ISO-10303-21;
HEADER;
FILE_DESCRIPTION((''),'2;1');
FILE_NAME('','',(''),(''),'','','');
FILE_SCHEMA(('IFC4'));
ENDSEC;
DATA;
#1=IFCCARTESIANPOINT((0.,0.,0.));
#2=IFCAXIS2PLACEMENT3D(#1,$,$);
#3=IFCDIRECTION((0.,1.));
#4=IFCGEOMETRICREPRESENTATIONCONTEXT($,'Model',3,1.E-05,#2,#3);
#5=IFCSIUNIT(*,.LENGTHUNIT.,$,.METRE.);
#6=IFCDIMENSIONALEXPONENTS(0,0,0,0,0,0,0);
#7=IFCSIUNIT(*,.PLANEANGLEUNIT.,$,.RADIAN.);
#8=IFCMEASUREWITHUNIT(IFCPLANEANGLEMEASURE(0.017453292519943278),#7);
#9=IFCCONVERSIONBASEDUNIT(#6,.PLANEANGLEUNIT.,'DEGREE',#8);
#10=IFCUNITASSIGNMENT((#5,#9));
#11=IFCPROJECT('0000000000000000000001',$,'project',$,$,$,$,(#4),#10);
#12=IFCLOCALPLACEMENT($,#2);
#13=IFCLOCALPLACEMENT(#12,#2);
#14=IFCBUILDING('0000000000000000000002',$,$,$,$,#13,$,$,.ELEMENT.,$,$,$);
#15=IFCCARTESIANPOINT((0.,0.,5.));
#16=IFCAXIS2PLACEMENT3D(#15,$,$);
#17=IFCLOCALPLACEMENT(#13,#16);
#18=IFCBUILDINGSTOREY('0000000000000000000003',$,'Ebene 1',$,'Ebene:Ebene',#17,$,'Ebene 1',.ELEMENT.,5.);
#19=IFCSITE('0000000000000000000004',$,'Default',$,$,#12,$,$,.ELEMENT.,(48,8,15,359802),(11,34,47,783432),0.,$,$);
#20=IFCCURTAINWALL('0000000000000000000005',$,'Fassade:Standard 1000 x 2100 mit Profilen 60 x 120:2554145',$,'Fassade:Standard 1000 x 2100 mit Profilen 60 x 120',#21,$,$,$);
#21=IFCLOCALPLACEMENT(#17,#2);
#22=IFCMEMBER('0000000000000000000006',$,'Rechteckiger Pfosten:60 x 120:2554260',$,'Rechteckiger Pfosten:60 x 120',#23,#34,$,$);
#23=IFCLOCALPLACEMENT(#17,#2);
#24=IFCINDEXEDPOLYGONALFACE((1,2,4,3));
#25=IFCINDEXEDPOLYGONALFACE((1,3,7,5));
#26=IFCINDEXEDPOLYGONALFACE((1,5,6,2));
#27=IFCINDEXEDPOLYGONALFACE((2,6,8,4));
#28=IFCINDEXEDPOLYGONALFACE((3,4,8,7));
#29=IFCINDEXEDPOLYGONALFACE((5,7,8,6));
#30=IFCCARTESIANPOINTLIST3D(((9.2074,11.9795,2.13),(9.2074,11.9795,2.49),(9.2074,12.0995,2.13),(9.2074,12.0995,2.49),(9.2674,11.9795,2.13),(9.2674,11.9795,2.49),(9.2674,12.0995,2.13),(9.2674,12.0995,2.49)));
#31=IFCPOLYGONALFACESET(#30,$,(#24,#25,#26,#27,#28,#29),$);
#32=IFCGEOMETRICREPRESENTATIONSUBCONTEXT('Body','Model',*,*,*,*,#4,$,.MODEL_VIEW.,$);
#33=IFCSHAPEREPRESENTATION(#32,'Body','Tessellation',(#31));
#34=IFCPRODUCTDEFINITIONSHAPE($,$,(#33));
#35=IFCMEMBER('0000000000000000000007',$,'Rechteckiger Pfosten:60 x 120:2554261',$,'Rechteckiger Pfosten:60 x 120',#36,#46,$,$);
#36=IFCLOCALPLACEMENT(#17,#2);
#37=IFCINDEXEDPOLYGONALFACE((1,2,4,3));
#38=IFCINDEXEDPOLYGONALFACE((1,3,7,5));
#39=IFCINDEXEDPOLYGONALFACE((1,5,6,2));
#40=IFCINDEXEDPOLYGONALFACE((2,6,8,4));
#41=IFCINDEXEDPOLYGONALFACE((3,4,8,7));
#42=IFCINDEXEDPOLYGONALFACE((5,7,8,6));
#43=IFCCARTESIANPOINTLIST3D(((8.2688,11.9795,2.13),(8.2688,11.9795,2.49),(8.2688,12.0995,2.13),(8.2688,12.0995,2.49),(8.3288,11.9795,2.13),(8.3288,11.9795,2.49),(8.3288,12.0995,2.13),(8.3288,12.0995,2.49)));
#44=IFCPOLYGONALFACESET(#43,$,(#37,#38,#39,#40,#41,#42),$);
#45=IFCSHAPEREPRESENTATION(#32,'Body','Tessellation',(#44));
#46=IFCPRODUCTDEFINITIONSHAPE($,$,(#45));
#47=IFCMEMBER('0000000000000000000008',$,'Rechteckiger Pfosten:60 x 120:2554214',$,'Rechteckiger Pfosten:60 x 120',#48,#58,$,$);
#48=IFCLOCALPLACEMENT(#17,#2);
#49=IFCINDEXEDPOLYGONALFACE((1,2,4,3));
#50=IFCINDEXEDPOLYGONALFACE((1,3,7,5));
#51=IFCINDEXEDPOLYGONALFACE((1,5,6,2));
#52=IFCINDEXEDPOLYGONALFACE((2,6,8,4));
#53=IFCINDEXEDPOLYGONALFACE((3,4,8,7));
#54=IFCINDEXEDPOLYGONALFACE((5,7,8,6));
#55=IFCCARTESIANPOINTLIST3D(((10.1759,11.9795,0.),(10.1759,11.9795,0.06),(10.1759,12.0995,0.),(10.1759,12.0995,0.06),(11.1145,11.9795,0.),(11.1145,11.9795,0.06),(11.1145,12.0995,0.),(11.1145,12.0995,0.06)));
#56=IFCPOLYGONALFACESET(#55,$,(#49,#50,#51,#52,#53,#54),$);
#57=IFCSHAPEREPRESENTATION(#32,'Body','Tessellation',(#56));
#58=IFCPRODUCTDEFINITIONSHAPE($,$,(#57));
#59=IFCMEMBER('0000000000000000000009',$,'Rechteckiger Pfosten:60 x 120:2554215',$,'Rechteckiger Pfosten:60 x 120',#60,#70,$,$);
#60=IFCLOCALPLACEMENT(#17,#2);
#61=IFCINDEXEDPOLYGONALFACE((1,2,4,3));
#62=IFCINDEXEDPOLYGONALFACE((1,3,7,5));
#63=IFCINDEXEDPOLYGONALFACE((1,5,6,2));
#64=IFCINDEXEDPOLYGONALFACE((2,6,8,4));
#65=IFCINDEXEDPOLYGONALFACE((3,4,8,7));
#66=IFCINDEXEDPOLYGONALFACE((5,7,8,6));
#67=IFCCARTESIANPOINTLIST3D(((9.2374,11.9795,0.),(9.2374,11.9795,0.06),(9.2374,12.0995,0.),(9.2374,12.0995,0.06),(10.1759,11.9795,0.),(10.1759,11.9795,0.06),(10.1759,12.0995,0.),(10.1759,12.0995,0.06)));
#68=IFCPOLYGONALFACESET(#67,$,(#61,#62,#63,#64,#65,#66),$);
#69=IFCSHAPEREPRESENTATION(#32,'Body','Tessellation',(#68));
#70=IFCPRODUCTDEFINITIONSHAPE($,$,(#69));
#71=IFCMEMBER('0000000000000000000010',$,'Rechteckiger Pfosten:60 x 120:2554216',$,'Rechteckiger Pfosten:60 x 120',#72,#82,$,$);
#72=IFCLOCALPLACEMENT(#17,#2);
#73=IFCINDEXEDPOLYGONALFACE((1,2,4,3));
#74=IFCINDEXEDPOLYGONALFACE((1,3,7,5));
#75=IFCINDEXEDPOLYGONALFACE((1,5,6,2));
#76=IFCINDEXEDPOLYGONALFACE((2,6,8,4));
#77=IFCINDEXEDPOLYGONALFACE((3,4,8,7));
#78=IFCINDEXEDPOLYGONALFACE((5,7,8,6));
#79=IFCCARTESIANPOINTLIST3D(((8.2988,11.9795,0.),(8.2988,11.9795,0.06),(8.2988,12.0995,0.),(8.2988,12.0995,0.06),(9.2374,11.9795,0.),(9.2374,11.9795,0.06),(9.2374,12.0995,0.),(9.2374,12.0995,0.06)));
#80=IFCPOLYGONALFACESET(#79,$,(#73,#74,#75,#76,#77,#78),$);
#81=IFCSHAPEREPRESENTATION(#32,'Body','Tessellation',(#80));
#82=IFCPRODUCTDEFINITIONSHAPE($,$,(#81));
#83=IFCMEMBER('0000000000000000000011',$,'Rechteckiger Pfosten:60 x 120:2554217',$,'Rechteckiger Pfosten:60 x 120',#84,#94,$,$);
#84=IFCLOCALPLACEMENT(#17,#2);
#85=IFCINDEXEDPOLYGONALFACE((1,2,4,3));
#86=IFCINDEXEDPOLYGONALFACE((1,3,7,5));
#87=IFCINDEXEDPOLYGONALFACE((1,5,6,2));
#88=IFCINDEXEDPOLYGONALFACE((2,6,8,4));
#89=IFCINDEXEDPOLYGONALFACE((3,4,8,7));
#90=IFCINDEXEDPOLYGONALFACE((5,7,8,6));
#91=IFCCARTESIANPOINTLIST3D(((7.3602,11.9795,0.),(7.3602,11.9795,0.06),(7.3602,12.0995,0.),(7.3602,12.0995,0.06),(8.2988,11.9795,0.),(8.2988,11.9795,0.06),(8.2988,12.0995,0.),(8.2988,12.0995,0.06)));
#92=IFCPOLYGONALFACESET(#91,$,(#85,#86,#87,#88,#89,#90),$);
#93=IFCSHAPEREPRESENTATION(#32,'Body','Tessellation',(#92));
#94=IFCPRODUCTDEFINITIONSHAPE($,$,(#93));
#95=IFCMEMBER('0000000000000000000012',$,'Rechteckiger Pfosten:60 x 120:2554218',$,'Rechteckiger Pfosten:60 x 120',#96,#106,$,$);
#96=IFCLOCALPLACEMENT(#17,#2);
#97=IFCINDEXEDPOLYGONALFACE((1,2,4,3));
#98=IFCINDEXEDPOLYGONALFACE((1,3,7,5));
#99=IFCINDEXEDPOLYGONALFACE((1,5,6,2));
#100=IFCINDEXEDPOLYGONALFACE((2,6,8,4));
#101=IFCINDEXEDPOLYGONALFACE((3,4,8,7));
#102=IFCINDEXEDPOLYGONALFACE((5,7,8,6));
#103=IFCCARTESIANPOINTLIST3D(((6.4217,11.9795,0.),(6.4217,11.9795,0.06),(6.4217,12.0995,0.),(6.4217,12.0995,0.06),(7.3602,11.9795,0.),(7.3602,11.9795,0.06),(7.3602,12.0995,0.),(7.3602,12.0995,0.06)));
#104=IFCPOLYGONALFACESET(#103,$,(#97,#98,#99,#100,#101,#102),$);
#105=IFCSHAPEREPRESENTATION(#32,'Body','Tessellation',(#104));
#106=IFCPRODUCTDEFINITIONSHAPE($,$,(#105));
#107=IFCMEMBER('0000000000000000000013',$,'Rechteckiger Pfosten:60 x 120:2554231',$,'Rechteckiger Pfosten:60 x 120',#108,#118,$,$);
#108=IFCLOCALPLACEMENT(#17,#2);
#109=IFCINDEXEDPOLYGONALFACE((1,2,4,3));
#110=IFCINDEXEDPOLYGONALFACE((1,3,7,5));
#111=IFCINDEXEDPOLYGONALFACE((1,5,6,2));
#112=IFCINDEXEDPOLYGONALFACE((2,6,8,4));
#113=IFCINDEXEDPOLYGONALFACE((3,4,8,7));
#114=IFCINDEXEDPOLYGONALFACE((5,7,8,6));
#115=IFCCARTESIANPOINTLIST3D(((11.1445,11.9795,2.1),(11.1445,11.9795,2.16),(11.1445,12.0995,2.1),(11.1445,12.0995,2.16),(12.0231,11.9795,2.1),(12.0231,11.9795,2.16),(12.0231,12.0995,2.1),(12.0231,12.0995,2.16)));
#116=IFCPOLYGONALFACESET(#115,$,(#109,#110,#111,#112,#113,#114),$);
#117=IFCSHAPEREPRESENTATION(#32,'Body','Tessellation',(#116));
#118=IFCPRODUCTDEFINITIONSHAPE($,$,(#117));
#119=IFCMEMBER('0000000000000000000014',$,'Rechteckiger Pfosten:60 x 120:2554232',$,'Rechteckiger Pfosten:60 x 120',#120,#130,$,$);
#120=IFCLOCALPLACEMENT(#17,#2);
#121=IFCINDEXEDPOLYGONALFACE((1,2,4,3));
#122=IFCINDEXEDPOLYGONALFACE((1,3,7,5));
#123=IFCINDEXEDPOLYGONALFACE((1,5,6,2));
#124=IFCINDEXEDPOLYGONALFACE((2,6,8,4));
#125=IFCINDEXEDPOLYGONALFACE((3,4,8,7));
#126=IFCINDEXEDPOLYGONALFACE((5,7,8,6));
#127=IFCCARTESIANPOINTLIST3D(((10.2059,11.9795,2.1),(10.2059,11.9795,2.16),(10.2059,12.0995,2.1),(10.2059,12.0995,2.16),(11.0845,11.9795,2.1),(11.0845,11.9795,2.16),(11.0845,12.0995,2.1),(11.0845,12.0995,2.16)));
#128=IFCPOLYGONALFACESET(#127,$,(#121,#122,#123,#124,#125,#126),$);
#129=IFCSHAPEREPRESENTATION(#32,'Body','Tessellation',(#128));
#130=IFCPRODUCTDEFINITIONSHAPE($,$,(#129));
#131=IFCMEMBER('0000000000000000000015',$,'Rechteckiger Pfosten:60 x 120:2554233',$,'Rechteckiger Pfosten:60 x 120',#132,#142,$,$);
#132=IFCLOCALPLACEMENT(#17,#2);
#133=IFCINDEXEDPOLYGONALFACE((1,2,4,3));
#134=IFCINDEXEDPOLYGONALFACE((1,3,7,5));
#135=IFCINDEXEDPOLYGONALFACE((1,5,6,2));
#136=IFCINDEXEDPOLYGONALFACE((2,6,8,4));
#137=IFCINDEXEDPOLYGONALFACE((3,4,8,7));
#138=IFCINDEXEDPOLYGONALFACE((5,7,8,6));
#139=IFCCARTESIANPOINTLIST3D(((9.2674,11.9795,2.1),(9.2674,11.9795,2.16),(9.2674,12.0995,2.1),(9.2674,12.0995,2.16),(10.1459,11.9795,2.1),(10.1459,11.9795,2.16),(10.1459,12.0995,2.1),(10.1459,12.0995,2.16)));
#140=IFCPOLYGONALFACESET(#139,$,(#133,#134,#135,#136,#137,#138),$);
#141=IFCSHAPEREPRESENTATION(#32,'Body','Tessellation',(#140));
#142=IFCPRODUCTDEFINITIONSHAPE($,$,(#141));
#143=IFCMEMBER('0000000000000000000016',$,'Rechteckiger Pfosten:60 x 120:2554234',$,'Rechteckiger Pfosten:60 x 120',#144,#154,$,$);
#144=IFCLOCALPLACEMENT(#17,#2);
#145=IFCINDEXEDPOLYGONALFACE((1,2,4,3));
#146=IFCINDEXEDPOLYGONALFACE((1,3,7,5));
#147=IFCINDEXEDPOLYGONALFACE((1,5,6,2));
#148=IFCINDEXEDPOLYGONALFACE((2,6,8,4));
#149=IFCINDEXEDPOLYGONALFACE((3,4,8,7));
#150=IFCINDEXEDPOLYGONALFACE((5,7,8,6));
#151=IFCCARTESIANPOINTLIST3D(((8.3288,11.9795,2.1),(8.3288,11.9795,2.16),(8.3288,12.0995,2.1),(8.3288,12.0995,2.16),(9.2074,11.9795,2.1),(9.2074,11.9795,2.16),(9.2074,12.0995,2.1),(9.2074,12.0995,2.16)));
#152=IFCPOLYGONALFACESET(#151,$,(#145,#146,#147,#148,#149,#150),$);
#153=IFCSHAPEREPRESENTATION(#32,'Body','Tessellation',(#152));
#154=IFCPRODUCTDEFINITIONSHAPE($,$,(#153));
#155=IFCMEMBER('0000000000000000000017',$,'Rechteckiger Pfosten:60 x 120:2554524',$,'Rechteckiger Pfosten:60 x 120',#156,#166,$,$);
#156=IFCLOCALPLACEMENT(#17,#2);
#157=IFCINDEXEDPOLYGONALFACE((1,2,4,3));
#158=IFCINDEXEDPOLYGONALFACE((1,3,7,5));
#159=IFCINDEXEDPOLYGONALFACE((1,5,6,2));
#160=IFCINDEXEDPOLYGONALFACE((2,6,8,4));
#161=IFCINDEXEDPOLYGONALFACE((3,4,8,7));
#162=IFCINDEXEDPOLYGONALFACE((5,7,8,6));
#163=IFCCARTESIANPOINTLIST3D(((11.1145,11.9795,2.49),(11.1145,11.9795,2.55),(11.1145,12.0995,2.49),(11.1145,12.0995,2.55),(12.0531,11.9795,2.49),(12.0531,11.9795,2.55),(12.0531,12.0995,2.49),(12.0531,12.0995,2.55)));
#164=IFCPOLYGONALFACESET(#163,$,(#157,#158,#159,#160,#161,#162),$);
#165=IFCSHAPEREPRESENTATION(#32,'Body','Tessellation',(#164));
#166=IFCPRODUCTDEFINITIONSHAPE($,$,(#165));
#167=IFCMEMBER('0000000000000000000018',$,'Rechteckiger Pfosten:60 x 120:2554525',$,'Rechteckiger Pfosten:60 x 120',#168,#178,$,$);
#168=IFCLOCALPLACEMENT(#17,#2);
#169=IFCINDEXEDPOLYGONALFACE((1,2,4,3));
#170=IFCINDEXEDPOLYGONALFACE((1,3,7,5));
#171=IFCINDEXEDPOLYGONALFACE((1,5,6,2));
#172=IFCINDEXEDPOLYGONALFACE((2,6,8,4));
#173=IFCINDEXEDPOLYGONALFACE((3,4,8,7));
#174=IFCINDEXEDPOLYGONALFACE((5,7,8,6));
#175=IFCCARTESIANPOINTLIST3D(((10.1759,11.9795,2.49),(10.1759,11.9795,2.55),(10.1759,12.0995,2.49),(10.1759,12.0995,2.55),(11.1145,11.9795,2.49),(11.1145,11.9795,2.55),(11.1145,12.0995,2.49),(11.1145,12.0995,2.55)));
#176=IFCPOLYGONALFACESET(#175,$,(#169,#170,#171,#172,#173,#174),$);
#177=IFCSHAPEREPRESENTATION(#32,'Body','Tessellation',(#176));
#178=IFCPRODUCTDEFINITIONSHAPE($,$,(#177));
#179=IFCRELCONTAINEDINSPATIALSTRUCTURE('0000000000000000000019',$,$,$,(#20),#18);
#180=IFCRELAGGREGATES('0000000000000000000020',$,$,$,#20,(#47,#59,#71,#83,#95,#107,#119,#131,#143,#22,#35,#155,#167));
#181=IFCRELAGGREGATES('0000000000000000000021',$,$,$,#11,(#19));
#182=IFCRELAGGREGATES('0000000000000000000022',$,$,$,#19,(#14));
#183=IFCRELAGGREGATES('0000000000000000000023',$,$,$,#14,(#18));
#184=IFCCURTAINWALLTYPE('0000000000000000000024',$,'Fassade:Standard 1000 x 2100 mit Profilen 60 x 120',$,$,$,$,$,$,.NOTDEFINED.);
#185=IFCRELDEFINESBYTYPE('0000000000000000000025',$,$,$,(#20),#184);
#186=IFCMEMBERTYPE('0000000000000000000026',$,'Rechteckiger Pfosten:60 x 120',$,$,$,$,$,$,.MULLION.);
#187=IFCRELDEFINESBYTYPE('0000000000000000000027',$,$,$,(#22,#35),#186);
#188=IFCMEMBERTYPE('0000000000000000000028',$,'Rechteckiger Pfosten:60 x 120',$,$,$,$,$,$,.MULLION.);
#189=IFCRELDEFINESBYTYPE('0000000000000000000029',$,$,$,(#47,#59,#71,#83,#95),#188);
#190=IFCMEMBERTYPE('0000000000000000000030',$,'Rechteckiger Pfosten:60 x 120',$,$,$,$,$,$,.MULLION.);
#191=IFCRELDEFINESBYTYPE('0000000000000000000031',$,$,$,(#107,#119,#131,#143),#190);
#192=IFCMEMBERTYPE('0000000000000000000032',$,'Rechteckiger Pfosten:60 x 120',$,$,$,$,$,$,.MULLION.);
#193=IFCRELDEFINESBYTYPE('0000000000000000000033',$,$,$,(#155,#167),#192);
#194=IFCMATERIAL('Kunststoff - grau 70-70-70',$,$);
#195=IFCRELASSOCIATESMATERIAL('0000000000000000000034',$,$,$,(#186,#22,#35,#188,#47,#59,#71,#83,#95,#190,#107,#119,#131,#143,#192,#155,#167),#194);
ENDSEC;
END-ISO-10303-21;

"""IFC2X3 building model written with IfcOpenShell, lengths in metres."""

from ifc_helpers import new_model, entity, si_unit, converted_unit, direction, frame, frame_2d, origin, origin_2d_with_axis, place, context, subcontext, project, spatial, rectangle, extrude, source, transform, mapped, material, type_object, type_shapes, element, aggregate, save


model = new_model("IFC2X3")

# Units and contexts
model_context = context("Model", 3, precision=1e-05, world=origin(), true_north=direction((0.0, 1.0)))
body_context = subcontext(model_context, "Body", "Model", "MODEL_VIEW")
ifc_project = project(units=[si_unit("LENGTHUNIT", "METRE"), converted_unit("PLANEANGLEUNIT", "DEGREE", entity("IfcPlaneAngleMeasure", 0.017453292519943278), si_unit("PLANEANGLEUNIT", "RADIAN"), dimensions=[0, 0, 0, 0, 0, 0, 0])], contexts=[model_context])

# Site, building, storey
site_placement = place(None, origin())
site = spatial("IfcSite", under=ifc_project, at=site_placement, Name="Default", CompositionType="ELEMENT", RefLatitude=(48, 8, 15, 359802), RefLongitude=(11, 34, 47, 783432), RefElevation=0.0)
building_placement = place(site_placement, origin())
building = spatial("IfcBuilding", under=site, at=building_placement, CompositionType="ELEMENT")
storey_placement = place(building_placement, frame((0.0, 0.0, 5.0)))
storey = spatial("IfcBuildingStorey", under=building, at=storey_placement, Name="Ebene 1", ObjectType="Ebene:Ebene", LongName="Ebene 1", CompositionType="ELEMENT", Elevation=5.0)

# Curtain wall, members
curtain_wall_type = type_object("IfcCurtainWallType", Name="Fassade:Standard 1000 x 2100 mit Profilen 60 x 120", PredefinedType="NOTDEFINED")
curtain_wall_placement = place(storey_placement, frame((0.0, 0.0, -5.0)))
curtain_wall = element("IfcCurtainWall", 1, at=curtain_wall_placement, inside=storey, type_object=curtain_wall_type, Name="Fassade:Standard 1000 x 2100 mit Profilen 60 x 120:2554145", ObjectType="Fassade:Standard 1000 x 2100 mit Profilen 60 x 120")
ifc_material_1 = material(Name="Kunststoff - grau 70-70-70")
member_type_1 = type_object("IfcMemberType", Name="Rechteckiger Pfosten:60 x 120", PredefinedType="MULLION", material=ifc_material_1)
shared_shape_1 = source(origin(), body_context, "Body", "SweptSolid", [
    extrude(rectangle(XDim=0.06, YDim=0.12, at=frame_2d((0.0, 0.0), x_axis=(1.0, 0.0))), frame((0.0, 0.0, -0.36), z_axis=(0.0, 0.0, 1.0), x_axis=(-1.0, 0.0, 0.0)), (0.0, 0.0, 1.0), 0.36),
])
type_shapes(member_type_1, [shared_shape_1])
member_1_placement = place(curtain_wall_placement, frame((9.2374, 12.0395, 7.13), z_axis=(0.0, 0.0, -1.0), x_axis=(-1.0, 0.0, 0.0)))
member_1 = element("IfcMember", 2, at=member_1_placement, type_object=member_type_1, material=ifc_material_1, Name="Rechteckiger Pfosten:60 x 120:2554260", ObjectType="Rechteckiger Pfosten:60 x 120", context=body_context, shape_type="MappedRepresentation", body=[
    mapped(shared_shape_1, transform((0.0, 0.0, 0.0), scale=1.0)),
])
member_2_placement = place(curtain_wall_placement, frame((8.2988, 12.0395, 7.13), z_axis=(0.0, 0.0, -1.0), x_axis=(-1.0, 0.0, 0.0)))
member_2 = element("IfcMember", 3, at=member_2_placement, type_object=member_type_1, material=ifc_material_1, Name="Rechteckiger Pfosten:60 x 120:2554261", ObjectType="Rechteckiger Pfosten:60 x 120", context=body_context, shape_type="MappedRepresentation", body=[
    mapped(shared_shape_1, transform((0.0, 0.0, 0.0), scale=1.0)),
])
member_type_2 = type_object("IfcMemberType", Name="Rechteckiger Pfosten:60 x 120", PredefinedType="MULLION", material=ifc_material_1)
shared_shape_2 = source(origin(), body_context, "Body", "SweptSolid", [
    extrude(rectangle(XDim=0.06, YDim=0.12, at=origin_2d_with_axis()), frame((-0.03, 0.0, -0.9386), z_axis=(0.0, 0.0, 1.0), x_axis=(-1.0, 0.0, 0.0)), (0.0, 0.0, 1.0), 0.9386),
])
type_shapes(member_type_2, [shared_shape_2])
member_3_placement = place(curtain_wall_placement, frame((11.1145, 12.0395, 5.0), z_axis=(1.0, 0.0, 0.0), x_axis=(0.0, 0.0, -1.0)))
member_3 = element("IfcMember", 4, at=member_3_placement, type_object=member_type_2, material=ifc_material_1, Name="Rechteckiger Pfosten:60 x 120:2554214", ObjectType="Rechteckiger Pfosten:60 x 120", context=body_context, shape_type="MappedRepresentation", body=[
    mapped(shared_shape_2, transform((0.0, 0.0, 0.0), scale=1.0)),
])
member_4_placement = place(curtain_wall_placement, frame((10.1759, 12.0395, 5.0), z_axis=(1.0, 0.0, 0.0), x_axis=(0.0, 0.0, -1.0)))
member_4 = element("IfcMember", 5, at=member_4_placement, type_object=member_type_2, material=ifc_material_1, Name="Rechteckiger Pfosten:60 x 120:2554215", ObjectType="Rechteckiger Pfosten:60 x 120", context=body_context, shape_type="MappedRepresentation", body=[
    mapped(shared_shape_2, transform((0.0, 0.0, 0.0), scale=1.0)),
])
member_5_placement = place(curtain_wall_placement, frame((9.2374, 12.0395, 5.0), z_axis=(1.0, 0.0, 0.0), x_axis=(0.0, 0.0, -1.0)))
member_5 = element("IfcMember", 6, at=member_5_placement, type_object=member_type_2, material=ifc_material_1, Name="Rechteckiger Pfosten:60 x 120:2554216", ObjectType="Rechteckiger Pfosten:60 x 120", context=body_context, shape_type="MappedRepresentation", body=[
    mapped(shared_shape_2, transform((0.0, 0.0, 0.0), scale=1.0)),
])
member_6_placement = place(curtain_wall_placement, frame((8.2988, 12.0395, 5.0), z_axis=(1.0, 0.0, 0.0), x_axis=(0.0, 0.0, -1.0)))
member_6 = element("IfcMember", 7, at=member_6_placement, type_object=member_type_2, material=ifc_material_1, Name="Rechteckiger Pfosten:60 x 120:2554217", ObjectType="Rechteckiger Pfosten:60 x 120", context=body_context, shape_type="MappedRepresentation", body=[
    mapped(shared_shape_2, transform((0.0, 0.0, 0.0), scale=1.0)),
])
member_7_placement = place(curtain_wall_placement, frame((7.3602, 12.0395, 5.0), z_axis=(1.0, 0.0, 0.0), x_axis=(0.0, 0.0, -1.0)))
member_7 = element("IfcMember", 8, at=member_7_placement, type_object=member_type_2, material=ifc_material_1, Name="Rechteckiger Pfosten:60 x 120:2554218", ObjectType="Rechteckiger Pfosten:60 x 120", context=body_context, shape_type="MappedRepresentation", body=[
    mapped(shared_shape_2, transform((0.0, 0.0, 0.0), scale=1.0)),
])
member_type_3 = type_object("IfcMemberType", Name="Rechteckiger Pfosten:60 x 120", PredefinedType="MULLION", material=ifc_material_1)
shared_shape_3 = source(origin(), body_context, "Body", "SweptSolid", [
    extrude(rectangle(XDim=0.06, YDim=0.12, at=frame_2d((0.0, 0.0), x_axis=(1.0, 0.0))), frame((0.0, 0.0, -0.8786), z_axis=(0.0, 0.0, 1.0), x_axis=(-1.0, 0.0, 0.0)), (0.0, 0.0, 1.0), 0.8786),
])
type_shapes(member_type_3, [shared_shape_3])
member_8_placement = place(curtain_wall_placement, frame((11.1445, 12.0395, 7.13), z_axis=(-1.0, 0.0, 0.0), x_axis=(0.0, 0.0, 1.0)))
member_8 = element("IfcMember", 9, at=member_8_placement, type_object=member_type_3, material=ifc_material_1, Name="Rechteckiger Pfosten:60 x 120:2554231", ObjectType="Rechteckiger Pfosten:60 x 120", context=body_context, shape_type="MappedRepresentation", body=[
    mapped(shared_shape_3, transform((0.0, 0.0, 0.0), scale=1.0)),
])
member_9_placement = place(curtain_wall_placement, frame((10.2059, 12.0395, 7.13), z_axis=(-1.0, 0.0, 0.0), x_axis=(0.0, 0.0, 1.0)))
member_9 = element("IfcMember", 10, at=member_9_placement, type_object=member_type_3, material=ifc_material_1, Name="Rechteckiger Pfosten:60 x 120:2554232", ObjectType="Rechteckiger Pfosten:60 x 120", context=body_context, shape_type="MappedRepresentation", body=[
    mapped(shared_shape_3, transform((0.0, 0.0, 0.0), scale=1.0)),
])
member_10_placement = place(curtain_wall_placement, frame((9.2674, 12.0395, 7.13), z_axis=(-1.0, 0.0, 0.0), x_axis=(0.0, 0.0, 1.0)))
member_10 = element("IfcMember", 11, at=member_10_placement, type_object=member_type_3, material=ifc_material_1, Name="Rechteckiger Pfosten:60 x 120:2554233", ObjectType="Rechteckiger Pfosten:60 x 120", context=body_context, shape_type="MappedRepresentation", body=[
    mapped(shared_shape_3, transform((0.0, 0.0, 0.0), scale=1.0)),
])
member_11_placement = place(curtain_wall_placement, frame((8.3288, 12.0395, 7.13), z_axis=(-1.0, 0.0, 0.0), x_axis=(0.0, 0.0, 1.0)))
member_11 = element("IfcMember", 12, at=member_11_placement, type_object=member_type_3, material=ifc_material_1, Name="Rechteckiger Pfosten:60 x 120:2554234", ObjectType="Rechteckiger Pfosten:60 x 120", context=body_context, shape_type="MappedRepresentation", body=[
    mapped(shared_shape_3, transform((0.0, 0.0, 0.0), scale=1.0)),
])
member_type_4 = type_object("IfcMemberType", Name="Rechteckiger Pfosten:60 x 120", PredefinedType="MULLION", material=ifc_material_1)
shared_shape_4 = source(origin(), body_context, "Body", "SweptSolid", [
    extrude(rectangle(XDim=0.06, YDim=0.12, at=origin_2d_with_axis()), frame((-0.03, 0.0, -0.9386), z_axis=(0.0, 0.0, 1.0), x_axis=(-1.0, 0.0, 0.0)), (0.0, 0.0, 1.0), 0.9386),
])
type_shapes(member_type_4, [shared_shape_4])
member_12_placement = place(curtain_wall_placement, frame((11.1145, 12.0395, 7.55), z_axis=(-1.0, 0.0, 0.0), x_axis=(0.0, 0.0, 1.0)))
member_12 = element("IfcMember", 13, at=member_12_placement, type_object=member_type_4, material=ifc_material_1, Name="Rechteckiger Pfosten:60 x 120:2554524", ObjectType="Rechteckiger Pfosten:60 x 120", context=body_context, shape_type="MappedRepresentation", body=[
    mapped(shared_shape_4, transform((0.0, 0.0, 0.0), scale=1.0)),
])
member_13_placement = place(curtain_wall_placement, frame((10.1759, 12.0395, 7.55), z_axis=(-1.0, 0.0, 0.0), x_axis=(0.0, 0.0, 1.0)))
member_13 = element("IfcMember", 14, at=member_13_placement, type_object=member_type_4, material=ifc_material_1, Name="Rechteckiger Pfosten:60 x 120:2554525", ObjectType="Rechteckiger Pfosten:60 x 120", context=body_context, shape_type="MappedRepresentation", body=[
    mapped(shared_shape_4, transform((0.0, 0.0, 0.0), scale=1.0)),
])

aggregate(curtain_wall, [member_3, member_4, member_5, member_6, member_7, member_8, member_9, member_10, member_11, member_1, member_2, member_12, member_13])

save(model, "model.ifc")
